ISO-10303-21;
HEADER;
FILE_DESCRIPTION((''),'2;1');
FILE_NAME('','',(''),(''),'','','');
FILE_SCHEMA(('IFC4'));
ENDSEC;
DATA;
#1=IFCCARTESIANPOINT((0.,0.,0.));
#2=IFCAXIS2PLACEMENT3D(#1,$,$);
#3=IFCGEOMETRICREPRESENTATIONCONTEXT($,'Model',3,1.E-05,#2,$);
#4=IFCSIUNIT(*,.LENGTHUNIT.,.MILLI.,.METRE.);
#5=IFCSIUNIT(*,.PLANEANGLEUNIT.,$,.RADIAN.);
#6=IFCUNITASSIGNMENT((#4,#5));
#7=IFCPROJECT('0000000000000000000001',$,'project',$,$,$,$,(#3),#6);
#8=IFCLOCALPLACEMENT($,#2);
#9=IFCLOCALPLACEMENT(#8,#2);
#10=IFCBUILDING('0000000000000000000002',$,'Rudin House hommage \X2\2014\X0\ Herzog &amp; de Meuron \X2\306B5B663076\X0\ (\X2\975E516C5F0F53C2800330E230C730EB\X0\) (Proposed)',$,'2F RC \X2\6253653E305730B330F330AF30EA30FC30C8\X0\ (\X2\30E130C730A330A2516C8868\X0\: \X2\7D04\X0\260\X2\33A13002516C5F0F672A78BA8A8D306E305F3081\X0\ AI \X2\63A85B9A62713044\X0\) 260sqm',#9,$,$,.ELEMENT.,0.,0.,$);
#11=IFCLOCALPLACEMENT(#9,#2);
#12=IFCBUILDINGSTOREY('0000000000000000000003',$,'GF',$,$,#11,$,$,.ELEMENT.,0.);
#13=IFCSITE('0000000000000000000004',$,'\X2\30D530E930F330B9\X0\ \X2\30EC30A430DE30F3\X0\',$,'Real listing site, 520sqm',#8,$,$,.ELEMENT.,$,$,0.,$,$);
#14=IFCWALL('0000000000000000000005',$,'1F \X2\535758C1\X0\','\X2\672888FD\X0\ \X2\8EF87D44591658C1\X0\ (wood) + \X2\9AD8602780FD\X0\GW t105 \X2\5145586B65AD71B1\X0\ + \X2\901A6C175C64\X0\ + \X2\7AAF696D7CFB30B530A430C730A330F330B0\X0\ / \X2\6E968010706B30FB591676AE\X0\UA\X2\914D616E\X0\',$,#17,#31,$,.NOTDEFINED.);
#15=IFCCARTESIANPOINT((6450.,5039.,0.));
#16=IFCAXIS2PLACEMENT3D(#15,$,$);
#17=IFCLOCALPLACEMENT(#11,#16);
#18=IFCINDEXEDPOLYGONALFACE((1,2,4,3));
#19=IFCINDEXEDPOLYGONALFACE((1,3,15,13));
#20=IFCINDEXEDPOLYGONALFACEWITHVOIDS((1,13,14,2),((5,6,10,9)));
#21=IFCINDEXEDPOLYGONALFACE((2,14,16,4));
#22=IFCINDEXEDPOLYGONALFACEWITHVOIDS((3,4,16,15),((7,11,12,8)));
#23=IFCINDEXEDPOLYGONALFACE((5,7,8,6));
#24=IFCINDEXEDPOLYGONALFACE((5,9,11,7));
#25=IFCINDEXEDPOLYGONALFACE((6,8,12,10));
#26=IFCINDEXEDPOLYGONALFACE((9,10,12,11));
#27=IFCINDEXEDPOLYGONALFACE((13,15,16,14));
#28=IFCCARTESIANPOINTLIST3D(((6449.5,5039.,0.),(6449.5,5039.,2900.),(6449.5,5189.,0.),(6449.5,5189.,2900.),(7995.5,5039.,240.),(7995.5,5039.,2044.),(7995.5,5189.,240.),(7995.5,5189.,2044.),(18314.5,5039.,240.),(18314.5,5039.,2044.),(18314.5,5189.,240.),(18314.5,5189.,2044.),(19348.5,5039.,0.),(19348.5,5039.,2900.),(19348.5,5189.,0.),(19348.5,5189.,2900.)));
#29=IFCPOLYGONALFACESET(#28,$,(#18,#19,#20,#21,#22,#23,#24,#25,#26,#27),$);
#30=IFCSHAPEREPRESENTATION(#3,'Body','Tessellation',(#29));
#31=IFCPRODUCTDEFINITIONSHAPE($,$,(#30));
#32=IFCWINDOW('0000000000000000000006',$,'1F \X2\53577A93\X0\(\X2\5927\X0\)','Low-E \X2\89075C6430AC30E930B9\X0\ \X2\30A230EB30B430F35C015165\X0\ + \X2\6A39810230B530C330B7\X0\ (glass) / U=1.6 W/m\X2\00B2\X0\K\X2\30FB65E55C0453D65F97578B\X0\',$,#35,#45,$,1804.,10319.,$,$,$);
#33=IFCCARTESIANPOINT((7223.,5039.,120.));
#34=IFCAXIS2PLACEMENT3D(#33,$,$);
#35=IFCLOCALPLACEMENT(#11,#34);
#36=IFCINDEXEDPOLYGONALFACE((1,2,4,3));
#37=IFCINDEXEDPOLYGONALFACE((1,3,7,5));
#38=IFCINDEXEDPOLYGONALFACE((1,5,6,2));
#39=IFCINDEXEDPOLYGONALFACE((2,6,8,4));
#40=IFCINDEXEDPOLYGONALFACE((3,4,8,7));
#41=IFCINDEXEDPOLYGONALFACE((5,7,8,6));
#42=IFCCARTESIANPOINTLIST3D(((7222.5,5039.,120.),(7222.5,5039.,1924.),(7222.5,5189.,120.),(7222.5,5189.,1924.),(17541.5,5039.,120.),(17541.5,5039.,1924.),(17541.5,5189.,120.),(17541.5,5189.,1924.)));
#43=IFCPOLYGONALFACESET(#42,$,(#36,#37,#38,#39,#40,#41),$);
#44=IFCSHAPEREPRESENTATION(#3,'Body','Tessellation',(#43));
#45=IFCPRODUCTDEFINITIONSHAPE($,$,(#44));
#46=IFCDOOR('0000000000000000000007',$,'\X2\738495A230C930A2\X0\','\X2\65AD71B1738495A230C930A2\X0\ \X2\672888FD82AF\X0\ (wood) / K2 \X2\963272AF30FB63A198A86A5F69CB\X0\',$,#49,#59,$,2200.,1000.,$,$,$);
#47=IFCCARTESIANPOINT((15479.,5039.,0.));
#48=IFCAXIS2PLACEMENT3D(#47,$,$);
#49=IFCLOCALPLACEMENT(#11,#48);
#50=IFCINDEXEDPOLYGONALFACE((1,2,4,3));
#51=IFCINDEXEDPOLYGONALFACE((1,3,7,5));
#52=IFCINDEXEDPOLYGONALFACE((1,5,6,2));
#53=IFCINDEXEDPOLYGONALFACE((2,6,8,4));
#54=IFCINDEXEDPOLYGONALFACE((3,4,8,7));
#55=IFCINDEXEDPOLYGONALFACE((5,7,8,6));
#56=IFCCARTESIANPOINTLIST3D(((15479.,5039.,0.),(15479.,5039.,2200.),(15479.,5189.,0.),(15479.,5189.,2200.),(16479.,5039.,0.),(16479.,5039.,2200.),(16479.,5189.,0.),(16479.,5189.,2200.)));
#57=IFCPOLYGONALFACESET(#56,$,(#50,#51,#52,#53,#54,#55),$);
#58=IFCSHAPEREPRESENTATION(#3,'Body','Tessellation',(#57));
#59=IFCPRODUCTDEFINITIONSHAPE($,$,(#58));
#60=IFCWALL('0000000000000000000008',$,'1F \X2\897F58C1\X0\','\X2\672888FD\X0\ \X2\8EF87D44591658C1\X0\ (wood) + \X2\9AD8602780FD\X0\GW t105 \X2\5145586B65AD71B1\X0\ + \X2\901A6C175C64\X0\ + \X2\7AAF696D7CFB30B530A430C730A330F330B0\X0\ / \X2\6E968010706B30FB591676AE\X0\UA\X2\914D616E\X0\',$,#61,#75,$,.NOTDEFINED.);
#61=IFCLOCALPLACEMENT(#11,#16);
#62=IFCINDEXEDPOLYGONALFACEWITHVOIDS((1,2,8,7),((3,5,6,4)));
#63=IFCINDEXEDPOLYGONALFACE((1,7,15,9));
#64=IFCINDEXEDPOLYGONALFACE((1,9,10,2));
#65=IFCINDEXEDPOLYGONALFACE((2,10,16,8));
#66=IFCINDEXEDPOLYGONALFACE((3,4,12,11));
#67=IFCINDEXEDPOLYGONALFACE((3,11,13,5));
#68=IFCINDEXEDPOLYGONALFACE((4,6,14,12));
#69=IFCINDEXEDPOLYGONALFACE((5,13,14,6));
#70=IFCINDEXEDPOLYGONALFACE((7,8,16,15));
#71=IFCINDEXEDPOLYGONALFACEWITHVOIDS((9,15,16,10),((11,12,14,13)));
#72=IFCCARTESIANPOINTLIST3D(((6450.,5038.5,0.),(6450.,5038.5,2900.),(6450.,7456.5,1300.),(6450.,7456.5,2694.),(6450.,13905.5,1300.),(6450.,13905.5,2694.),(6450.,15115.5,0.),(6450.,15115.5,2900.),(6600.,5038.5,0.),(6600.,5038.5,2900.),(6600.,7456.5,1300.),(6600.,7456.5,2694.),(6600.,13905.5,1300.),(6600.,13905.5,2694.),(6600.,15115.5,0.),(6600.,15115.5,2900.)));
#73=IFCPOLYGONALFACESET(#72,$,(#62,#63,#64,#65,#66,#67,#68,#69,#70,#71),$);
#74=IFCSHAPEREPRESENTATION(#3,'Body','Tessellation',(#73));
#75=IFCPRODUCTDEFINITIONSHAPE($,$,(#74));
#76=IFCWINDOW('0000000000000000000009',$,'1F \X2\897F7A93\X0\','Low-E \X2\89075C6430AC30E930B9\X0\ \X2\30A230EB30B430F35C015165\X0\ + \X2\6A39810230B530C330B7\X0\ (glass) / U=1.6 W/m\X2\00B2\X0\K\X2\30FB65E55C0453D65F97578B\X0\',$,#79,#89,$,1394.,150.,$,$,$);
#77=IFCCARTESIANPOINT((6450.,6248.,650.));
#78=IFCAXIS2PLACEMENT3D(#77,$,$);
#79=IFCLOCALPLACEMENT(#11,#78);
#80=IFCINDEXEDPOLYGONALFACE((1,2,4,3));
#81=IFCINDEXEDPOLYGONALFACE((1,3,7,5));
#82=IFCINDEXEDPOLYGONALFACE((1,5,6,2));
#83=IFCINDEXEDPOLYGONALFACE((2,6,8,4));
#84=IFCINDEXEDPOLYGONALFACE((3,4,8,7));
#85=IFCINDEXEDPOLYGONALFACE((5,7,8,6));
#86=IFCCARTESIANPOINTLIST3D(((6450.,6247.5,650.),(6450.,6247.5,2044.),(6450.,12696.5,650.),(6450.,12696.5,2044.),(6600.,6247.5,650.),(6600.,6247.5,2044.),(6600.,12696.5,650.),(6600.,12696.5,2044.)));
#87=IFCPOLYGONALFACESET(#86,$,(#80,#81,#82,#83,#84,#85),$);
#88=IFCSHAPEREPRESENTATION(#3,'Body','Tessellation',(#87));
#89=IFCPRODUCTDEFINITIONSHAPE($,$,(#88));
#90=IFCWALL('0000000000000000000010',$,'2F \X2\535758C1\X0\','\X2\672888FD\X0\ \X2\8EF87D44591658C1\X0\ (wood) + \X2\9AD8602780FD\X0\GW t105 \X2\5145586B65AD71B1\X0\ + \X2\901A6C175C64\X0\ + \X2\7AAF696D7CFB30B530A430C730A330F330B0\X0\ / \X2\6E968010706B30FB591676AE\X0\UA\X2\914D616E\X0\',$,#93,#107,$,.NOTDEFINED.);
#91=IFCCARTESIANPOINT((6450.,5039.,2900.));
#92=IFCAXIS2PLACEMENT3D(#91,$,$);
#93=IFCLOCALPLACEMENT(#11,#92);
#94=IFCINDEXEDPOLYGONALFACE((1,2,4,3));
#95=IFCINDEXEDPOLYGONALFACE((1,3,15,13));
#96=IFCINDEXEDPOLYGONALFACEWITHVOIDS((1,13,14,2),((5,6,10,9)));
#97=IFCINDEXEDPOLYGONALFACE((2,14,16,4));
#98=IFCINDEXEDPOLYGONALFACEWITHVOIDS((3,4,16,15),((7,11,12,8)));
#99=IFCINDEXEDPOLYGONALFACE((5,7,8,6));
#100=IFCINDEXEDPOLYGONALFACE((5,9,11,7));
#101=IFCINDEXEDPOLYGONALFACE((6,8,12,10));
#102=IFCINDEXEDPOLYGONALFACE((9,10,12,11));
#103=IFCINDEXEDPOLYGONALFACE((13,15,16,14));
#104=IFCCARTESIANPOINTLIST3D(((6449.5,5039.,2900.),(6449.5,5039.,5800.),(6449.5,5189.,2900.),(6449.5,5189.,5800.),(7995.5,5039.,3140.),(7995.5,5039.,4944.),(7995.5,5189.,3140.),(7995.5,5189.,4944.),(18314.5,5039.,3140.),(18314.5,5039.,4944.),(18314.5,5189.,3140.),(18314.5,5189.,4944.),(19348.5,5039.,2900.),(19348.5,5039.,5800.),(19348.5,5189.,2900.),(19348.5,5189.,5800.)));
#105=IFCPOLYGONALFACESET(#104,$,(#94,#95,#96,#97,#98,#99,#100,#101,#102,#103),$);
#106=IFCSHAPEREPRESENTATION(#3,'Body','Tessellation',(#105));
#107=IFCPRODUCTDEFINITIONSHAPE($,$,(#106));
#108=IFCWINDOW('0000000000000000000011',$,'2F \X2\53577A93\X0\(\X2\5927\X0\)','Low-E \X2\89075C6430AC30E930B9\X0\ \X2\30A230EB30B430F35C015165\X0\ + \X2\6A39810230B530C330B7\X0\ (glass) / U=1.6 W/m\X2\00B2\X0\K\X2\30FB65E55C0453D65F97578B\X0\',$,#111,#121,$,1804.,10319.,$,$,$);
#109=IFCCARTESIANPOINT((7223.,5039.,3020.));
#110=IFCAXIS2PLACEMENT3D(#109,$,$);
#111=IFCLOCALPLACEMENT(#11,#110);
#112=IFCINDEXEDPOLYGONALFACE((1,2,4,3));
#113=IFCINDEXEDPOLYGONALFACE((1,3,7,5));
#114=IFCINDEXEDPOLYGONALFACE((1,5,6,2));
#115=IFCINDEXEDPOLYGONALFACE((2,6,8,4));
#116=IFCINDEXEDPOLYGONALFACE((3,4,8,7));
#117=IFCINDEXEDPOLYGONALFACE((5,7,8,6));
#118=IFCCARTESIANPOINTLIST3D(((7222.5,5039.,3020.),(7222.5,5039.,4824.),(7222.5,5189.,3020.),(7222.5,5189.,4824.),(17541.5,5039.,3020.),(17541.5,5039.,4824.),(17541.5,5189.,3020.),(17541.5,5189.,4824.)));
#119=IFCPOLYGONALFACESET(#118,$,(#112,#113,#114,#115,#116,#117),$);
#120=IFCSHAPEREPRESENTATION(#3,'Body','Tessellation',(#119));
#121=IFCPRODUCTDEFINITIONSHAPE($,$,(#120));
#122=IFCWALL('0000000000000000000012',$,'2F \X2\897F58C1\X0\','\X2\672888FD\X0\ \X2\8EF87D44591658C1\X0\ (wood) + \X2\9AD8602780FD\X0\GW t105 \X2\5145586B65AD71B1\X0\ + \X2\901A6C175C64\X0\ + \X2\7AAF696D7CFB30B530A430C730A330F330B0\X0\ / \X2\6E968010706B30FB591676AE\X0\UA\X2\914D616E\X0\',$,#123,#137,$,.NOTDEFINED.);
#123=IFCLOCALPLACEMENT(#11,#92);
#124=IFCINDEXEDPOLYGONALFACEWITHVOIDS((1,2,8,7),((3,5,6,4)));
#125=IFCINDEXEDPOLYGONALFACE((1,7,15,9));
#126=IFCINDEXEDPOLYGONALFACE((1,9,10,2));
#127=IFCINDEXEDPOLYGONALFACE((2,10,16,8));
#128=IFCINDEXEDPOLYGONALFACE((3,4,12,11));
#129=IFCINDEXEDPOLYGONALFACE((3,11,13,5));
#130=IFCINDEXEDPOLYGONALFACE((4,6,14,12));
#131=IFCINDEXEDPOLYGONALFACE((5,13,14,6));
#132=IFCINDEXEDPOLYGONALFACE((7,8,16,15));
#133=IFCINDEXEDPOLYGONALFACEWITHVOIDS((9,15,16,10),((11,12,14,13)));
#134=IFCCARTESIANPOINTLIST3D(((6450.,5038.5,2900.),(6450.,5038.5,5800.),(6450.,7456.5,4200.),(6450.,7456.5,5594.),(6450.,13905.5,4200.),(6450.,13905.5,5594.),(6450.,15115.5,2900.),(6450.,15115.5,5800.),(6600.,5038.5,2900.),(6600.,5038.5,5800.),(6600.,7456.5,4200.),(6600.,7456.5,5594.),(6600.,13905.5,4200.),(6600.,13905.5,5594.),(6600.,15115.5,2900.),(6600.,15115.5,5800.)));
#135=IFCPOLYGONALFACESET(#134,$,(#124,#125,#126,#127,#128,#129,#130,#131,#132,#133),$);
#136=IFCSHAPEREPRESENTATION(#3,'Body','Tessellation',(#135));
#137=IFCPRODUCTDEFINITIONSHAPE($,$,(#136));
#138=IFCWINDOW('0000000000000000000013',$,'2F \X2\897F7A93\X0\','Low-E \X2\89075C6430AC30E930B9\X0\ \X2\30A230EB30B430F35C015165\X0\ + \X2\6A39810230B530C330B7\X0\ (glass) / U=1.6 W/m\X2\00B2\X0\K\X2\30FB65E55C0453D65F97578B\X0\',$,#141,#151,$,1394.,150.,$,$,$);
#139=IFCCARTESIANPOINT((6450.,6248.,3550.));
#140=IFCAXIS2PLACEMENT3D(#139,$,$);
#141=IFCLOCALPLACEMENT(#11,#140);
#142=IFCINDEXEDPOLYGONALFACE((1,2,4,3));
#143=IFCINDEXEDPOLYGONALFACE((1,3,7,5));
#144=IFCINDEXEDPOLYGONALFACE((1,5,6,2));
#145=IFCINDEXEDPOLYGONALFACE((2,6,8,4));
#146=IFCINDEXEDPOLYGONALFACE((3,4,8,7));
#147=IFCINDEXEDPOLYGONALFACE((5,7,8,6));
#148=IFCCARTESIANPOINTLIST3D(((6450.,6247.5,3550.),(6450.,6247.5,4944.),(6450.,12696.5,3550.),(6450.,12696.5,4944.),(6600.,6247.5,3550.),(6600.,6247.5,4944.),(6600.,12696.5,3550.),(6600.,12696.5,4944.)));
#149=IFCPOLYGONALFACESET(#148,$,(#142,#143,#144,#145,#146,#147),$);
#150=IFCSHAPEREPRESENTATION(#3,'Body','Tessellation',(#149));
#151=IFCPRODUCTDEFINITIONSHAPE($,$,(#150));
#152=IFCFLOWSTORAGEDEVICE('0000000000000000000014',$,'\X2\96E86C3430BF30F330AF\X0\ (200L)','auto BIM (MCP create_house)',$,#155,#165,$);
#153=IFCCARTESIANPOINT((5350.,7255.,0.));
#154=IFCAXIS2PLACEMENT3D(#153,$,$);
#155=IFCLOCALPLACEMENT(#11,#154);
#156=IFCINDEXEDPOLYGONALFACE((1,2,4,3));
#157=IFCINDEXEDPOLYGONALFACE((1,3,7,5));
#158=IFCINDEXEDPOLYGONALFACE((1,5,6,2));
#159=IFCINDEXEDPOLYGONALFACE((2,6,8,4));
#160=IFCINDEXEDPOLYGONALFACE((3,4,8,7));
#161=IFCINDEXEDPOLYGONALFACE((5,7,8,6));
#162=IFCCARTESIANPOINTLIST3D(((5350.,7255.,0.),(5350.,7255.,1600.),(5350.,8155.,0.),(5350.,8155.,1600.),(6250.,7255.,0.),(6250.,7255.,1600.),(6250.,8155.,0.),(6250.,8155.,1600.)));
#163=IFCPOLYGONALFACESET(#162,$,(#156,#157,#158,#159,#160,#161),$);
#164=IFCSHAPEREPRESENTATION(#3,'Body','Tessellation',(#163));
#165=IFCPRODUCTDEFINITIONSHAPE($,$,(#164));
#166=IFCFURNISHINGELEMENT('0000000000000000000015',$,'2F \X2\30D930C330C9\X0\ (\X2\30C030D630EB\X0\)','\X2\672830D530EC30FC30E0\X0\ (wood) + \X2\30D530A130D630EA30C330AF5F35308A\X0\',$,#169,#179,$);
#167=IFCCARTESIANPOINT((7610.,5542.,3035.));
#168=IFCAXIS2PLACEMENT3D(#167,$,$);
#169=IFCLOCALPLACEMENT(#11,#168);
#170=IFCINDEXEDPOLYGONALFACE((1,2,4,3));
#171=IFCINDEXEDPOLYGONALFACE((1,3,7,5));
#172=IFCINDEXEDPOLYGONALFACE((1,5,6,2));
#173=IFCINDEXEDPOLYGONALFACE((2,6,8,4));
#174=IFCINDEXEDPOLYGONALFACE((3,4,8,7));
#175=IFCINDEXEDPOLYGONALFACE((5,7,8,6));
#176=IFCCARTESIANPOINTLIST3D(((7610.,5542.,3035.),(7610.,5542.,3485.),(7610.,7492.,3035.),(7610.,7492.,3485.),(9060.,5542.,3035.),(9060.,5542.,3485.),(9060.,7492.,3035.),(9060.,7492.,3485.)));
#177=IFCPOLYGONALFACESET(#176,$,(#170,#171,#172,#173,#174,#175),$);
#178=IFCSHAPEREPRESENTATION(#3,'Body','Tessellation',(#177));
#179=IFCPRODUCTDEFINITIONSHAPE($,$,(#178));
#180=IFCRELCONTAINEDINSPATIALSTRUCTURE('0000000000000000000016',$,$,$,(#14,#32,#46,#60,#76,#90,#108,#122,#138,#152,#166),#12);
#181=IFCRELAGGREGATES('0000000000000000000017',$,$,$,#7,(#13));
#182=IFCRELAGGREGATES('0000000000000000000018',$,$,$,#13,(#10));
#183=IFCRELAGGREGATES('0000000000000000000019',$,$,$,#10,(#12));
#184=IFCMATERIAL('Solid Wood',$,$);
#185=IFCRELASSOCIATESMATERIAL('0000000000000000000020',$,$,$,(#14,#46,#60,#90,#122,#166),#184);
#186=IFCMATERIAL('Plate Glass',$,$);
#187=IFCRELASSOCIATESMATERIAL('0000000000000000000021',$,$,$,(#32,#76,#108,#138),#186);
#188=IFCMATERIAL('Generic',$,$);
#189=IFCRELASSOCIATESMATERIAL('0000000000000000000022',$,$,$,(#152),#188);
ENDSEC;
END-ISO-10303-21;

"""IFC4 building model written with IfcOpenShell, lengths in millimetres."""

from ifc_helpers import new_model, si_unit, frame, frame_2d, origin, place, context, project, spatial, rectangle, extrude, material, element, fill, save


model = new_model("IFC4")

# Units and contexts
model_context = context("Model", 3, precision=1e-05, world=origin())
ifc_project = project(units=[si_unit("LENGTHUNIT", "METRE", prefix="MILLI"), si_unit("PLANEANGLEUNIT", "RADIAN")], contexts=[model_context])

# Site, building, storey
site_placement = place(None, origin())
site = spatial("IfcSite", under=ifc_project, at=site_placement, Name="フランス レイマン", ObjectType="Real listing site, 520sqm", CompositionType="ELEMENT", RefElevation=0.0)
building_placement = place(site_placement, origin())
building = spatial("IfcBuilding", under=site, at=building_placement, Name="Rudin House hommage — Herzog &amp; de Meuron に学ぶ (非公式参考モデル) (Proposed)", ObjectType="2F RC 打放しコンクリート (メディア公表: 約260㎡。公式未確認のため AI 推定扱い) 260sqm", CompositionType="ELEMENT", ElevationOfRefHeight=0.0, ElevationOfTerrain=0.0)
storey_placement = place(building_placement, origin())
storey = spatial("IfcBuildingStorey", under=building, at=storey_placement, Name="GF", CompositionType="ELEMENT", Elevation=0.0)

# Shared definitions
ifc_material_1 = material(Name="Solid Wood")

# Wall, openings, window, door
wall_1_placement = place(storey_placement, frame((6450.0, 5039.0, 0.0)))
wall_1 = element("IfcWall", 1, at=wall_1_placement, inside=storey, material=ifc_material_1, Name="1F 南壁", Description="木製 軸組外壁 (wood) + 高性能GW t105 充填断熱 + 通気層 + 窯業系サイディング / 準耐火・外皮UA配慮", PredefinedType="NOTDEFINED", context=model_context, shape_type="SweptSolid", body=[
    extrude(rectangle(XDim=12899.0, YDim=150.0, at=frame_2d((6449.0, 75.0))), frame((6450.0, 5039.0, 0.0)), (0.0, 0.0, 1.0), 2900.0),
])
opening_1_placement = place(storey_placement, frame((7223.0, 5039.0, 120.0)))
opening_1 = element("IfcOpeningElement", 2, at=opening_1_placement, cuts=wall_1, PredefinedType="NOTDEFINED", context=model_context, shape_type="SweptSolid", body=[
    extrude(rectangle(XDim=10319.0, YDim=150.0, at=frame_2d((5159.0, 75.0))), frame((7223.0, 5039.0, 120.0)), (0.0, 0.0, 1.0), 1804.0),
])
opening_2_placement = place(storey_placement, frame((15479.0, 5039.0, 0.0)))
opening_2 = element("IfcOpeningElement", 3, at=opening_2_placement, cuts=wall_1, PredefinedType="NOTDEFINED", context=model_context, shape_type="SweptSolid", body=[
    extrude(rectangle(XDim=1000.0, YDim=150.0, at=frame_2d((500.0, 75.0))), frame((15479.0, 5039.0, 0.0)), (0.0, 0.0, 1.0), 2200.0),
])
ifc_material_2 = material(Name="Plate Glass")
window_1_placement = place(storey_placement, frame((7223.0, 5039.0, 120.0)))
window_1 = element("IfcWindow", 4, at=window_1_placement, inside=storey, material=ifc_material_2, Name="1F 南窓(大)", Description="Low-E 複層ガラス アルゴン封入 + 樹脂サッシ (glass) / U=1.6 W/m²K・日射取得型", OverallHeight=1804.0, OverallWidth=10319.0, context=model_context, shape_type="SweptSolid", body=[
    extrude(rectangle(XDim=10319.0, YDim=150.0, at=frame_2d((5159.0, 75.0))), frame((7223.0, 5039.0, 120.0)), (0.0, 0.0, 1.0), 1804.0),
])
fill(opening_1, window_1)
door_placement = place(storey_placement, frame((15479.0, 5039.0, 0.0)))
door = element("IfcDoor", 5, at=door_placement, inside=storey, material=ifc_material_1, Name="玄関ドア", Description="断熱玄関ドア 木製芯 (wood) / K2 防犯・採風機構", OverallHeight=2200.0, OverallWidth=1000.0, context=model_context, shape_type="SweptSolid", body=[
    extrude(rectangle(XDim=1000.0, YDim=150.0, at=frame_2d((500.0, 75.0))), frame((15479.0, 5039.0, 0.0)), (0.0, 0.0, 1.0), 2200.0),
])
fill(opening_2, door)

# Wall, opening, window
wall_2_placement = place(storey_placement, frame((6450.0, 5039.0, 0.0)))
wall_2 = element("IfcWall", 6, at=wall_2_placement, inside=storey, material=ifc_material_1, Name="1F 西壁", Description="木製 軸組外壁 (wood) + 高性能GW t105 充填断熱 + 通気層 + 窯業系サイディング / 準耐火・外皮UA配慮", PredefinedType="NOTDEFINED", context=model_context, shape_type="SweptSolid", body=[
    extrude(rectangle(XDim=150.0, YDim=10077.0, at=frame_2d((75.0, 5038.0))), frame((6450.0, 5039.0, 0.0)), (0.0, 0.0, 1.0), 2900.0),
])
opening_3_placement = place(storey_placement, frame((6450.0, 6248.0, 650.0)))
opening_3 = element("IfcOpeningElement", 7, at=opening_3_placement, cuts=wall_2, PredefinedType="NOTDEFINED", context=model_context, shape_type="SweptSolid", body=[
    extrude(rectangle(XDim=150.0, YDim=6449.0, at=frame_2d((75.0, 3224.0))), frame((6450.0, 6248.0, 650.0)), (0.0, 0.0, 1.0), 1394.0),
])
window_2_placement = place(storey_placement, frame((6450.0, 6248.0, 650.0)))
window_2 = element("IfcWindow", 8, at=window_2_placement, inside=storey, material=ifc_material_2, Name="1F 西窓", Description="Low-E 複層ガラス アルゴン封入 + 樹脂サッシ (glass) / U=1.6 W/m²K・日射取得型", OverallHeight=1394.0, OverallWidth=150.0, context=model_context, shape_type="SweptSolid", body=[
    extrude(rectangle(XDim=150.0, YDim=6449.0, at=frame_2d((75.0, 3224.0))), frame((6450.0, 6248.0, 650.0)), (0.0, 0.0, 1.0), 1394.0),
])
fill(opening_3, window_2)

# Walls, openings, windows
wall_3_placement = place(storey_placement, frame((6450.0, 5039.0, 2900.0)))
wall_3 = element("IfcWall", 9, at=wall_3_placement, inside=storey, material=ifc_material_1, Name="2F 南壁", Description="木製 軸組外壁 (wood) + 高性能GW t105 充填断熱 + 通気層 + 窯業系サイディング / 準耐火・外皮UA配慮", PredefinedType="NOTDEFINED", context=model_context, shape_type="SweptSolid", body=[
    extrude(rectangle(XDim=12899.0, YDim=150.0, at=frame_2d((6449.0, 75.0))), frame((6450.0, 5039.0, 2900.0)), (0.0, 0.0, 1.0), 2900.0),
])
opening_4_placement = place(storey_placement, frame((7223.0, 5039.0, 3020.0)))
opening_4 = element("IfcOpeningElement", 10, at=opening_4_placement, cuts=wall_3, PredefinedType="NOTDEFINED", context=model_context, shape_type="SweptSolid", body=[
    extrude(rectangle(XDim=10319.0, YDim=150.0, at=frame_2d((5159.0, 75.0))), frame((7223.0, 5039.0, 3020.0)), (0.0, 0.0, 1.0), 1804.0),
])
window_3_placement = place(storey_placement, frame((7223.0, 5039.0, 3020.0)))
window_3 = element("IfcWindow", 11, at=window_3_placement, inside=storey, material=ifc_material_2, Name="2F 南窓(大)", Description="Low-E 複層ガラス アルゴン封入 + 樹脂サッシ (glass) / U=1.6 W/m²K・日射取得型", OverallHeight=1804.0, OverallWidth=10319.0, context=model_context, shape_type="SweptSolid", body=[
    extrude(rectangle(XDim=10319.0, YDim=150.0, at=frame_2d((5159.0, 75.0))), frame((7223.0, 5039.0, 3020.0)), (0.0, 0.0, 1.0), 1804.0),
])
fill(opening_4, window_3)
wall_4_placement = place(storey_placement, frame((6450.0, 5039.0, 2900.0)))
wall_4 = element("IfcWall", 12, at=wall_4_placement, inside=storey, material=ifc_material_1, Name="2F 西壁", Description="木製 軸組外壁 (wood) + 高性能GW t105 充填断熱 + 通気層 + 窯業系サイディング / 準耐火・外皮UA配慮", PredefinedType="NOTDEFINED", context=model_context, shape_type="SweptSolid", body=[
    extrude(rectangle(XDim=150.0, YDim=10077.0, at=frame_2d((75.0, 5038.0))), frame((6450.0, 5039.0, 2900.0)), (0.0, 0.0, 1.0), 2900.0),
])
opening_5_placement = place(storey_placement, frame((6450.0, 6248.0, 3550.0)))
opening_5 = element("IfcOpeningElement", 13, at=opening_5_placement, cuts=wall_4, PredefinedType="NOTDEFINED", context=model_context, shape_type="SweptSolid", body=[
    extrude(rectangle(XDim=150.0, YDim=6449.0, at=frame_2d((75.0, 3224.0))), frame((6450.0, 6248.0, 3550.0)), (0.0, 0.0, 1.0), 1394.0),
])
window_4_placement = place(storey_placement, frame((6450.0, 6248.0, 3550.0)))
window_4 = element("IfcWindow", 14, at=window_4_placement, inside=storey, material=ifc_material_2, Name="2F 西窓", Description="Low-E 複層ガラス アルゴン封入 + 樹脂サッシ (glass) / U=1.6 W/m²K・日射取得型", OverallHeight=1394.0, OverallWidth=150.0, context=model_context, shape_type="SweptSolid", body=[
    extrude(rectangle(XDim=150.0, YDim=6449.0, at=frame_2d((75.0, 3224.0))), frame((6450.0, 6248.0, 3550.0)), (0.0, 0.0, 1.0), 1394.0),
])
fill(opening_5, window_4)

# Shared definitions
ifc_material_3 = material(Name="Generic")

# Flow storage device
flow_storage_device_placement = place(storey_placement, frame((5350.0, 7255.0, 0.0)))
element("IfcFlowStorageDevice", 15, at=flow_storage_device_placement, inside=storey, material=ifc_material_3, Name="雨水タンク (200L)", Description="auto BIM (MCP create_house)", context=model_context, shape_type="SweptSolid", body=[
    extrude(rectangle(XDim=900.0, YDim=900.0, at=frame_2d((450.0, 450.0))), frame((5350.0, 7255.0, 0.0)), (0.0, 0.0, 1.0), 1600.0),
])

# Furnishing element
furnishing_placement = place(storey_placement, frame((7610.0, 5542.0, 3035.0)))
element("IfcFurnishingElement", 16, at=furnishing_placement, inside=storey, material=ifc_material_1, Name="2F ベッド (ダブル)", Description="木フレーム (wood) + ファブリック張り", context=model_context, shape_type="SweptSolid", body=[
    extrude(rectangle(XDim=1450.0, YDim=1950.0, at=frame_2d((725.0, 975.0))), frame((7610.0, 5542.0, 3035.0)), (0.0, 0.0, 1.0), 450.0),
])

save(model, "model.ifc")
